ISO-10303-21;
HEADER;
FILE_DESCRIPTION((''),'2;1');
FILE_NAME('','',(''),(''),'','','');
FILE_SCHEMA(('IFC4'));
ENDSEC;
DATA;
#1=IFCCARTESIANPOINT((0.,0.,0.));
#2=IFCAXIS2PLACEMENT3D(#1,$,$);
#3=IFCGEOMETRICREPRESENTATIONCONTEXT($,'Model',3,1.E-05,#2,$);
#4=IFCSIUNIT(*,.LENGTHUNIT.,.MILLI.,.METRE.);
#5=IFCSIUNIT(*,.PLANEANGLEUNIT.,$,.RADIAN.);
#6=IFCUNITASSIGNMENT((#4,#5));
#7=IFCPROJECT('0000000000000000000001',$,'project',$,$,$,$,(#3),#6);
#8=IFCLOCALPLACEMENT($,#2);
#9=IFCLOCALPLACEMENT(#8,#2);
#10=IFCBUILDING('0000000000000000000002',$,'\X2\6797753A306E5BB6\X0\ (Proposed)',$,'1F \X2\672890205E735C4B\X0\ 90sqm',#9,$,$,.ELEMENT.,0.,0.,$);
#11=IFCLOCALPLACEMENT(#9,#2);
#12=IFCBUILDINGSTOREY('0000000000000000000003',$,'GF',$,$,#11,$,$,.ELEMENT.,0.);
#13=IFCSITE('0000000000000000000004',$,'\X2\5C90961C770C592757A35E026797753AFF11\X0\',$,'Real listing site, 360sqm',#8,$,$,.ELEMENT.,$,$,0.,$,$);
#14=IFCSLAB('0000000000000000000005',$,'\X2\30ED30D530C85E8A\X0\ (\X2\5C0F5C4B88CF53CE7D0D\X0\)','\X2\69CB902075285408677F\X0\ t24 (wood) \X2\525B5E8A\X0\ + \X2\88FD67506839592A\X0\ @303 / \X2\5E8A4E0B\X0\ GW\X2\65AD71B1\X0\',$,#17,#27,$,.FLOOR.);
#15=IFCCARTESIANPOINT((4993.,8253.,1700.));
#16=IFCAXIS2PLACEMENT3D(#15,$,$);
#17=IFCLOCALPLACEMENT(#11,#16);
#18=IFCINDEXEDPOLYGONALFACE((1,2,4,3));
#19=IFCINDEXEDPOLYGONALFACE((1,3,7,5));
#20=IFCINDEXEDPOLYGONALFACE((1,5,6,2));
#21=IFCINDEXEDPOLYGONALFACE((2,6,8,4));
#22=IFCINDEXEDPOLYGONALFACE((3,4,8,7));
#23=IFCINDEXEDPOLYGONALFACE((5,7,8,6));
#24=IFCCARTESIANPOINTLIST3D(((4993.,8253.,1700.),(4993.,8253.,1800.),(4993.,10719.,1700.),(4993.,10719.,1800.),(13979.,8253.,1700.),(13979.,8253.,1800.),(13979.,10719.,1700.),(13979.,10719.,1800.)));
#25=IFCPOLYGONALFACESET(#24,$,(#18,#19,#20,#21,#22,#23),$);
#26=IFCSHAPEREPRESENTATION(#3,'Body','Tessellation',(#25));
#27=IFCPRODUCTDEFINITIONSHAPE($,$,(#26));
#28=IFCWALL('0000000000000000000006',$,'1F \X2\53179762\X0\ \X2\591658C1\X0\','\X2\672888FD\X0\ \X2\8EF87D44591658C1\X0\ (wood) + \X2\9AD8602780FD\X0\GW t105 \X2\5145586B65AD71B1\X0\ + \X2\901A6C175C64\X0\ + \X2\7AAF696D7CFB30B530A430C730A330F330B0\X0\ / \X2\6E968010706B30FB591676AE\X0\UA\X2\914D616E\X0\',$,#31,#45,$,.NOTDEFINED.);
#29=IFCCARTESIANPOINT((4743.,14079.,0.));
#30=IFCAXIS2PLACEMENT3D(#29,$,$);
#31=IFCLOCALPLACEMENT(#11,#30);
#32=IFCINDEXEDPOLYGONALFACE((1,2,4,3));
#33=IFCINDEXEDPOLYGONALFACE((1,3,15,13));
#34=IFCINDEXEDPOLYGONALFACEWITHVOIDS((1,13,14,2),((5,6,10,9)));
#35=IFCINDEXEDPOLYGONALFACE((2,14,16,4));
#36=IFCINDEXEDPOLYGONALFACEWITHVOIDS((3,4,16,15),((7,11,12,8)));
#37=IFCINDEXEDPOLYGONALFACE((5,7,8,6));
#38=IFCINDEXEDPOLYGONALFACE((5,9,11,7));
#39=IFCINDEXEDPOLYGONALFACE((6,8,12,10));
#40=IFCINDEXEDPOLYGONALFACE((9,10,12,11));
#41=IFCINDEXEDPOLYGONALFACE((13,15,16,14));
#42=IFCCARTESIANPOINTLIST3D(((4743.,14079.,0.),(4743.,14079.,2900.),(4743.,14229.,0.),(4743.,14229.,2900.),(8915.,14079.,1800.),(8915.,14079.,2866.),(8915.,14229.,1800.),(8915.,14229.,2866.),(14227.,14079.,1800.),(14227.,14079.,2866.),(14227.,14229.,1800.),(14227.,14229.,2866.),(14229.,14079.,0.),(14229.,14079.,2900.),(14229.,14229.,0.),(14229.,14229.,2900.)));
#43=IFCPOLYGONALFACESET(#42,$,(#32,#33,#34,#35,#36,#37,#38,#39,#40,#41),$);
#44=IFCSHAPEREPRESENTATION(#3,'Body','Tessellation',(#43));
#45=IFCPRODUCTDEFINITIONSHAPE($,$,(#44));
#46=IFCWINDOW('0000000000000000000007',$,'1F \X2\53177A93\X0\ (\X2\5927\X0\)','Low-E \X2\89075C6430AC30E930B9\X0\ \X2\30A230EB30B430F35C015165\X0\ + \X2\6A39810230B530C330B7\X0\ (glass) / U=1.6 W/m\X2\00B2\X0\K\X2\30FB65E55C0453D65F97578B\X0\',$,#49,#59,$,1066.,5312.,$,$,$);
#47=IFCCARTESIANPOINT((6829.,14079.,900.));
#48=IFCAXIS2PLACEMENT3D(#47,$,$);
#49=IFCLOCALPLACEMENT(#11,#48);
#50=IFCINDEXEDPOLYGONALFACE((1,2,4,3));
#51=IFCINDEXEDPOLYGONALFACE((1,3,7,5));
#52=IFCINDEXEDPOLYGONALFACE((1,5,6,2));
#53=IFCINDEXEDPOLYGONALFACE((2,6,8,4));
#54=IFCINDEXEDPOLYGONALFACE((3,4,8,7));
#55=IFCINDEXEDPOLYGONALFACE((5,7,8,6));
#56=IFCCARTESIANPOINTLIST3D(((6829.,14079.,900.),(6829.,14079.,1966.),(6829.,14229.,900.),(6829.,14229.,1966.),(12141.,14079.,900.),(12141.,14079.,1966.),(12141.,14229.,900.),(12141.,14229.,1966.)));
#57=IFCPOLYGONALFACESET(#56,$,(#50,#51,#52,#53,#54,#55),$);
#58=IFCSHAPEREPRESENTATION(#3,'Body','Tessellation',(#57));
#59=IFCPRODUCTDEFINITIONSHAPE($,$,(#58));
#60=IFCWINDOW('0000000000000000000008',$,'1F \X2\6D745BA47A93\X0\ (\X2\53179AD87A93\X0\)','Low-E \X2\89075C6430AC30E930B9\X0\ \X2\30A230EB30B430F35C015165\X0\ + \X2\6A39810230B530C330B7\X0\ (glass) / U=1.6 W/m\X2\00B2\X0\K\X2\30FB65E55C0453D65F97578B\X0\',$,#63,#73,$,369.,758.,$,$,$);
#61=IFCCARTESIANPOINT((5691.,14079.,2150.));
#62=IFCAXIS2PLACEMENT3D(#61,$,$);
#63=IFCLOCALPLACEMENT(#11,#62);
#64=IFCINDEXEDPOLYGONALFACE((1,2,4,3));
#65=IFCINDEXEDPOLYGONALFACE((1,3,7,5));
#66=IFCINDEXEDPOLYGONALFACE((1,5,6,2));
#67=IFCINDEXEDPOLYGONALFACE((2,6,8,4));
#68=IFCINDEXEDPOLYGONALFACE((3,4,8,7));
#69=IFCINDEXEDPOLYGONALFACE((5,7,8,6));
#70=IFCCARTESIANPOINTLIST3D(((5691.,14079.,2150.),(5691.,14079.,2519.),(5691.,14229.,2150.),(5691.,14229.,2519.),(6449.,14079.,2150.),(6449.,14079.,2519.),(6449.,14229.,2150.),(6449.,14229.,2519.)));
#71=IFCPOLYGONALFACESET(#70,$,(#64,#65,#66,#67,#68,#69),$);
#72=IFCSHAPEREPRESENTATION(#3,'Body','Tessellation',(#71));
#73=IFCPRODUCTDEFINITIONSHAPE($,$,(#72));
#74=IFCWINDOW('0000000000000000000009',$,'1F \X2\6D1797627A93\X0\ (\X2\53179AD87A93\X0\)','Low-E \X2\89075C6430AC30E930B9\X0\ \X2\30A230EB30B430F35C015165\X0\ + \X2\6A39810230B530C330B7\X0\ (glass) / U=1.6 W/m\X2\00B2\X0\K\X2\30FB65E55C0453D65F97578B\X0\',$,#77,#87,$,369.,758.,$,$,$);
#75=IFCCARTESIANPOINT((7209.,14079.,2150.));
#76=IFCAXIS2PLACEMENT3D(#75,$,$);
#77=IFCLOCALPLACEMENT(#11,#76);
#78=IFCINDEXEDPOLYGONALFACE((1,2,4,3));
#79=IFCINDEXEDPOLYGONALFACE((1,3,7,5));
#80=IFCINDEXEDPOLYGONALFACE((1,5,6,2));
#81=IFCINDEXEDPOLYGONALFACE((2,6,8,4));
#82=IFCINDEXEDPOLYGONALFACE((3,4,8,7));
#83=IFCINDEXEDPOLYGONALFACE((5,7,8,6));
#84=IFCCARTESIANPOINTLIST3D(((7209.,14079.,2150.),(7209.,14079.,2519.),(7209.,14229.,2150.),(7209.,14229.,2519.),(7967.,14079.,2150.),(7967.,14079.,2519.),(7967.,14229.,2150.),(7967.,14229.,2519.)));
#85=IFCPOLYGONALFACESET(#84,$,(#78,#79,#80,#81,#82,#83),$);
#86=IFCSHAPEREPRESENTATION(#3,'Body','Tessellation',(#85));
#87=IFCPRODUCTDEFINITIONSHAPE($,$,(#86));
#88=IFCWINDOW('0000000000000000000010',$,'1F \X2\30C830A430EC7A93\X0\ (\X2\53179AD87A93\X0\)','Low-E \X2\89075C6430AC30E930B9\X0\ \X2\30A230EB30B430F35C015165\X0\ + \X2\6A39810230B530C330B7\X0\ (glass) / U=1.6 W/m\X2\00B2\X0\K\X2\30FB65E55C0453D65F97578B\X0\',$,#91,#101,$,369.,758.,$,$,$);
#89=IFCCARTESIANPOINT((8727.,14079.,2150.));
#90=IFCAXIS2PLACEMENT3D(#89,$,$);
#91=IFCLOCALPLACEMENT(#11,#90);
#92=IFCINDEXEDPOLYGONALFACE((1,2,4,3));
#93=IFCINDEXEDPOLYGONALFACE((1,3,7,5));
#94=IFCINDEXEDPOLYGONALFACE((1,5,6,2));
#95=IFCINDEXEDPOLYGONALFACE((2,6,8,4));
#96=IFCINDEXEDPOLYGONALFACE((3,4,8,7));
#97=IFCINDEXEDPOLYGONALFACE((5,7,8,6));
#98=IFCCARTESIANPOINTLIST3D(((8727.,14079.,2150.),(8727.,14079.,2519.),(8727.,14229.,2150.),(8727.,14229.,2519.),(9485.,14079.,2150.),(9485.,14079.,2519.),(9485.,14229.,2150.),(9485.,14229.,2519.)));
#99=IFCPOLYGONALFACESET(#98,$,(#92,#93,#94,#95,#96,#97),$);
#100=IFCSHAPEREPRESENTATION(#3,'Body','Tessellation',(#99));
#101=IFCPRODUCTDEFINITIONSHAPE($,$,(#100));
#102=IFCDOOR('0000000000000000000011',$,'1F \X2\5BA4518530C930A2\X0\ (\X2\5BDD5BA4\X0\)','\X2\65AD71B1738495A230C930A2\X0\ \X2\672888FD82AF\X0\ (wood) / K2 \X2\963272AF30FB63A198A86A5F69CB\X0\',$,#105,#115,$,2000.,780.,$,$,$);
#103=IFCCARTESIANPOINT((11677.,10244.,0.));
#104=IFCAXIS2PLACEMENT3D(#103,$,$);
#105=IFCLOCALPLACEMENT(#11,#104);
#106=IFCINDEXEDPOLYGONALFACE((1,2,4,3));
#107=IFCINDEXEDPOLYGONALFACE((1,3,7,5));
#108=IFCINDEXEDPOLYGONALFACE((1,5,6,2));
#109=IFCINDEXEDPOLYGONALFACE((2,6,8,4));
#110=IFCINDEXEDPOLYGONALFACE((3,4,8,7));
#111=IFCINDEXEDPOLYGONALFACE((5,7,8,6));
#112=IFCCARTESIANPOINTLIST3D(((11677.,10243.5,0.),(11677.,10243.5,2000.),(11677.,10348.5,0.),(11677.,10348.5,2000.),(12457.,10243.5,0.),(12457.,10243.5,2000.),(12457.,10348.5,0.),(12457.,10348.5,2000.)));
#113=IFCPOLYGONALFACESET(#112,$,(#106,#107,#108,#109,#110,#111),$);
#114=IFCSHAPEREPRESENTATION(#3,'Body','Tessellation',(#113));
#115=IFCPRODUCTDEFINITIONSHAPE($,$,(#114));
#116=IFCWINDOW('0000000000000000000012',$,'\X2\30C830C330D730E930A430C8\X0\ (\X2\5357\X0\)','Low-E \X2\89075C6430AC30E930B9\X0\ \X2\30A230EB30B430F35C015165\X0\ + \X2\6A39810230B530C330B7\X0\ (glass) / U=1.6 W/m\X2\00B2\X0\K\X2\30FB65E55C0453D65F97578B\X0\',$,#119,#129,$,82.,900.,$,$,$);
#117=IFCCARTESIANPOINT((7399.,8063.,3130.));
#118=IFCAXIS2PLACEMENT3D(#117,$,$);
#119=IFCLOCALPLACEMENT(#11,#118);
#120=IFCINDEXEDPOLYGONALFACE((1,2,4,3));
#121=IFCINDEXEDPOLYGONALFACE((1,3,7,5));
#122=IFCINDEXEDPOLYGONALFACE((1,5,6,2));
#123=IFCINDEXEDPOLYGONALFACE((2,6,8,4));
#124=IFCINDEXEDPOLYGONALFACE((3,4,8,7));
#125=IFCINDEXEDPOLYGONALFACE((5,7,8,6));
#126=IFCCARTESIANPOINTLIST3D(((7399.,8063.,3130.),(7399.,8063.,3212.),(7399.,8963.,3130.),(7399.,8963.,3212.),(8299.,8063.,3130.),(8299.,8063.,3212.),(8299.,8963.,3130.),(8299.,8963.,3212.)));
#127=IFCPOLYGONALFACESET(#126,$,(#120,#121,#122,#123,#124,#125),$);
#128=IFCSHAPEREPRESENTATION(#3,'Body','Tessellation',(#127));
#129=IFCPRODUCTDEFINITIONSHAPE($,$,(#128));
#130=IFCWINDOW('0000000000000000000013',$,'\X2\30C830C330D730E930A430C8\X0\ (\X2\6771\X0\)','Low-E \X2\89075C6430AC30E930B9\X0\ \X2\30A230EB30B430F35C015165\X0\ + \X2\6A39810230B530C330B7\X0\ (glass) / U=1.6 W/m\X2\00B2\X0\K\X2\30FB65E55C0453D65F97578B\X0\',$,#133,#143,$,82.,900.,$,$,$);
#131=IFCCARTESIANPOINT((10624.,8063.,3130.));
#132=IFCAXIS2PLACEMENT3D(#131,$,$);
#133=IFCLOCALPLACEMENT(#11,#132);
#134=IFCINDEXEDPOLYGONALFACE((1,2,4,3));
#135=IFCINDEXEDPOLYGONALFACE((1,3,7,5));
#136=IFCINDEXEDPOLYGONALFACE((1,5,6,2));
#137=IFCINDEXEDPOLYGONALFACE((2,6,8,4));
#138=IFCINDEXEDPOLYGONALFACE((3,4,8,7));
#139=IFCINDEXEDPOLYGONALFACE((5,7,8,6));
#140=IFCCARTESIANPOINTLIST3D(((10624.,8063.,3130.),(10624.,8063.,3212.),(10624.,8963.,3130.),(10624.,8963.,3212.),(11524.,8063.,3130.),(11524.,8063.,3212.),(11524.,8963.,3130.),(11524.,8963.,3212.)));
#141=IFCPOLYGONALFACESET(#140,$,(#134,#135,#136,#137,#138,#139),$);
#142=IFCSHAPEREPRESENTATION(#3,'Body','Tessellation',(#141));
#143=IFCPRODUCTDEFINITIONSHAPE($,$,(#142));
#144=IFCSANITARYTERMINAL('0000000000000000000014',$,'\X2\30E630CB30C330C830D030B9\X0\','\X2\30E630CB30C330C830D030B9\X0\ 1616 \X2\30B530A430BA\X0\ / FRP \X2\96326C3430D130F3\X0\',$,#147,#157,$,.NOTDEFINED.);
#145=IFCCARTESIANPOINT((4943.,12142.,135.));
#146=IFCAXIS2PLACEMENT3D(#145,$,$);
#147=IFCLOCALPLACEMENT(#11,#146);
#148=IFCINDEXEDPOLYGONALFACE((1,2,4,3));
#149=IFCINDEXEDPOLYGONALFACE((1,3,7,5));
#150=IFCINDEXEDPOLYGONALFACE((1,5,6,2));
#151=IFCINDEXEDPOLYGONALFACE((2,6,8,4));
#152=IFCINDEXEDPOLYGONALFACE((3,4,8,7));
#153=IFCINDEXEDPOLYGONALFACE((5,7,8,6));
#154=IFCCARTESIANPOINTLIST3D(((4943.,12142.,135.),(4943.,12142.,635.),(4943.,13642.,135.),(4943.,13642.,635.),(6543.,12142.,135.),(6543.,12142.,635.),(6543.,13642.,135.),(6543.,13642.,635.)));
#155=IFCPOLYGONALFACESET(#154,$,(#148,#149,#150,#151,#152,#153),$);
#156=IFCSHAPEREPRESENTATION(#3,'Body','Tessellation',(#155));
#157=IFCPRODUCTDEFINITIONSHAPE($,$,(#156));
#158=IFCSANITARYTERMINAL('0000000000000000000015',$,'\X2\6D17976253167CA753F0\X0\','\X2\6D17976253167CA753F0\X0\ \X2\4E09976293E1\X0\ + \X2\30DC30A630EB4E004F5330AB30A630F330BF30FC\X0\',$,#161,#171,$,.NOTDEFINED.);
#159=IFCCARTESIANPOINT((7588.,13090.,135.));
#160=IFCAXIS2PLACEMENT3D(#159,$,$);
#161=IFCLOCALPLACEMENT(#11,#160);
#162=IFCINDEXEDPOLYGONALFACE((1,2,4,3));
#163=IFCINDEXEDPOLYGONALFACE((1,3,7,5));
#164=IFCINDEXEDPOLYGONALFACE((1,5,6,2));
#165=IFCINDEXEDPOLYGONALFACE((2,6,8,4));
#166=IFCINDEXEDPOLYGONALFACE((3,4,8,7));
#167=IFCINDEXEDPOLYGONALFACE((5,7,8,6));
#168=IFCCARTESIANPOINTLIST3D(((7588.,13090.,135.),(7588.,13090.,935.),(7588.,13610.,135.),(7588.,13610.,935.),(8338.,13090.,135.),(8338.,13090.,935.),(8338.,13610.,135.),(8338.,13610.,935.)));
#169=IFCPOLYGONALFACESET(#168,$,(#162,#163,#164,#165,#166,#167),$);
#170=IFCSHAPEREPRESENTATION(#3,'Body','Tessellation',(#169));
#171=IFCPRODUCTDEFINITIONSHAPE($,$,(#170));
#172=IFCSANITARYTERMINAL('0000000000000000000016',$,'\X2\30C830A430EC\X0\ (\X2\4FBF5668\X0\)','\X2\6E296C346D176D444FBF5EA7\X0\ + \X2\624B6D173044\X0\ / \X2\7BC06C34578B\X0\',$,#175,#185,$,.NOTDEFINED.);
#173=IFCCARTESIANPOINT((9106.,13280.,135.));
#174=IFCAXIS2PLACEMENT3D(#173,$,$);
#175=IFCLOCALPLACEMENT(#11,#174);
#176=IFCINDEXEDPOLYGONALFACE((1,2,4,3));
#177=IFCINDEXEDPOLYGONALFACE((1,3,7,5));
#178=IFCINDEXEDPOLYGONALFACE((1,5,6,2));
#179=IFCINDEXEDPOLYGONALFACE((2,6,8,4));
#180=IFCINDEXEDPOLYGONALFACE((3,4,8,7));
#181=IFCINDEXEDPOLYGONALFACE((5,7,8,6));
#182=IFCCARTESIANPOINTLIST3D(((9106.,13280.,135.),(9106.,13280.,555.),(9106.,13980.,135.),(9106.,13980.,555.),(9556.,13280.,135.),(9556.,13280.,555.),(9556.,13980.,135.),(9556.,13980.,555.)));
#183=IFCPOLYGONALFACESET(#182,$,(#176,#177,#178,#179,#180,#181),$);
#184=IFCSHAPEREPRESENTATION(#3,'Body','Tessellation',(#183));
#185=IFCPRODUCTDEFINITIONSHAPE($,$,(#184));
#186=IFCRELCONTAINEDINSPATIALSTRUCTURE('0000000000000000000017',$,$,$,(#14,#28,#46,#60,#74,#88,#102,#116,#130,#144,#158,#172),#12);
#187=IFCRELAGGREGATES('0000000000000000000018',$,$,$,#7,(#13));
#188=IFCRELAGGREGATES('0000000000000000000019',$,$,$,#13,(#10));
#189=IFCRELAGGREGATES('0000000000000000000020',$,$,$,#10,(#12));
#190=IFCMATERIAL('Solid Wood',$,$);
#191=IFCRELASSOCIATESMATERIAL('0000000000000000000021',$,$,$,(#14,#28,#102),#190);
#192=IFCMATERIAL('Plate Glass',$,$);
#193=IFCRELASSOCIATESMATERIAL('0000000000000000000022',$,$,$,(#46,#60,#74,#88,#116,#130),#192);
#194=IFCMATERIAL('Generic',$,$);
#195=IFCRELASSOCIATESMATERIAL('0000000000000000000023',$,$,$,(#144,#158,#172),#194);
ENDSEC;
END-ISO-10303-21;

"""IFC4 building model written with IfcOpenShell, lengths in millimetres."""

from ifc_helpers import new_model, si_unit, frame, frame_2d, origin, place, context, project, spatial, rectangle, extrude, material, element, fill, save


model = new_model("IFC4")

# Units and contexts
model_context = context("Model", 3, precision=1e-05, world=origin())
ifc_project = project(units=[si_unit("LENGTHUNIT", "METRE", prefix="MILLI"), si_unit("PLANEANGLEUNIT", "RADIAN")], contexts=[model_context])

# Site, building, storey
site_placement = place(None, origin())
site = spatial("IfcSite", under=ifc_project, at=site_placement, Name="岐阜県大垣市林町１", ObjectType="Real listing site, 360sqm", CompositionType="ELEMENT", RefElevation=0.0)
building_placement = place(site_placement, origin())
building = spatial("IfcBuilding", under=site, at=building_placement, Name="林町の家 (Proposed)", ObjectType="1F 木造平屋 90sqm", CompositionType="ELEMENT", ElevationOfRefHeight=0.0, ElevationOfTerrain=0.0)
storey_placement = place(building_placement, origin())
storey = spatial("IfcBuildingStorey", under=building, at=storey_placement, Name="GF", CompositionType="ELEMENT", Elevation=0.0)

# Slab
ifc_material_1 = material(Name="Solid Wood")
slab_placement = place(storey_placement, frame((4993.0, 8253.0, 1700.0)))
element("IfcSlab", 1, at=slab_placement, inside=storey, material=ifc_material_1, Name="ロフト床 (小屋裏収納)", Description="構造用合板 t24 (wood) 剛床 + 製材根太 @303 / 床下 GW断熱", PredefinedType="FLOOR", context=model_context, shape_type="SweptSolid", body=[
    extrude(rectangle(XDim=8986.0, YDim=2466.0, at=frame_2d((4493.0, 1233.0))), frame((4993.0, 8253.0, 1700.0)), (0.0, 0.0, 1.0), 100.0),
])

# Wall, openings, windows
wall_1_placement = place(storey_placement, frame((4743.0, 14079.0, 0.0)))
wall_1 = element("IfcWall", 2, at=wall_1_placement, inside=storey, material=ifc_material_1, Name="1F 北面 外壁", Description="木製 軸組外壁 (wood) + 高性能GW t105 充填断熱 + 通気層 + 窯業系サイディング / 準耐火・外皮UA配慮", PredefinedType="NOTDEFINED", context=model_context, shape_type="SweptSolid", body=[
    extrude(rectangle(XDim=9486.0, YDim=150.0, at=frame_2d((4743.0, 75.0))), frame((4743.0, 14079.0, 0.0)), (0.0, 0.0, 1.0), 2900.0),
])
opening_1_placement = place(storey_placement, frame((6829.0, 14079.0, 900.0)))
opening_1 = element("IfcOpeningElement", 3, at=opening_1_placement, cuts=wall_1, PredefinedType="NOTDEFINED", context=model_context, shape_type="SweptSolid", body=[
    extrude(rectangle(XDim=5312.0, YDim=150.0, at=frame_2d((2656.0, 75.0))), frame((6829.0, 14079.0, 900.0)), (0.0, 0.0, 1.0), 1066.0),
])
opening_2_placement = place(storey_placement, frame((5691.0, 14079.0, 2150.0)))
opening_2 = element("IfcOpeningElement", 4, at=opening_2_placement, cuts=wall_1, PredefinedType="NOTDEFINED", context=model_context, shape_type="SweptSolid", body=[
    extrude(rectangle(XDim=758.0, YDim=150.0, at=frame_2d((379.0, 75.0))), frame((5691.0, 14079.0, 2150.0)), (0.0, 0.0, 1.0), 369.0),
])
opening_3_placement = place(storey_placement, frame((7209.0, 14079.0, 2150.0)))
opening_3 = element("IfcOpeningElement", 5, at=opening_3_placement, cuts=wall_1, PredefinedType="NOTDEFINED", context=model_context, shape_type="SweptSolid", body=[
    extrude(rectangle(XDim=758.0, YDim=150.0, at=frame_2d((379.0, 75.0))), frame((7209.0, 14079.0, 2150.0)), (0.0, 0.0, 1.0), 369.0),
])
opening_4_placement = place(storey_placement, frame((8727.0, 14079.0, 2150.0)))
opening_4 = element("IfcOpeningElement", 6, at=opening_4_placement, cuts=wall_1, PredefinedType="NOTDEFINED", context=model_context, shape_type="SweptSolid", body=[
    extrude(rectangle(XDim=758.0, YDim=150.0, at=frame_2d((379.0, 75.0))), frame((8727.0, 14079.0, 2150.0)), (0.0, 0.0, 1.0), 369.0),
])
ifc_material_2 = material(Name="Plate Glass")
window_1_placement = place(storey_placement, frame((6829.0, 14079.0, 900.0)))
window_1 = element("IfcWindow", 7, at=window_1_placement, inside=storey, material=ifc_material_2, Name="1F 北窓 (大)", Description="Low-E 複層ガラス アルゴン封入 + 樹脂サッシ (glass) / U=1.6 W/m²K・日射取得型", OverallHeight=1066.0, OverallWidth=5312.0, context=model_context, shape_type="SweptSolid", body=[
    extrude(rectangle(XDim=5312.0, YDim=150.0, at=frame_2d((2656.0, 75.0))), frame((6829.0, 14079.0, 900.0)), (0.0, 0.0, 1.0), 1066.0),
])
fill(opening_1, window_1)
window_2_placement = place(storey_placement, frame((5691.0, 14079.0, 2150.0)))
window_2 = element("IfcWindow", 8, at=window_2_placement, inside=storey, material=ifc_material_2, Name="1F 浴室窓 (北高窓)", Description="Low-E 複層ガラス アルゴン封入 + 樹脂サッシ (glass) / U=1.6 W/m²K・日射取得型", OverallHeight=369.0, OverallWidth=758.0, context=model_context, shape_type="SweptSolid", body=[
    extrude(rectangle(XDim=758.0, YDim=150.0, at=frame_2d((379.0, 75.0))), frame((5691.0, 14079.0, 2150.0)), (0.0, 0.0, 1.0), 369.0),
])
fill(opening_2, window_2)
window_3_placement = place(storey_placement, frame((7209.0, 14079.0, 2150.0)))
window_3 = element("IfcWindow", 9, at=window_3_placement, inside=storey, material=ifc_material_2, Name="1F 洗面窓 (北高窓)", Description="Low-E 複層ガラス アルゴン封入 + 樹脂サッシ (glass) / U=1.6 W/m²K・日射取得型", OverallHeight=369.0, OverallWidth=758.0, context=model_context, shape_type="SweptSolid", body=[
    extrude(rectangle(XDim=758.0, YDim=150.0, at=frame_2d((379.0, 75.0))), frame((7209.0, 14079.0, 2150.0)), (0.0, 0.0, 1.0), 369.0),
])
fill(opening_3, window_3)
window_4_placement = place(storey_placement, frame((8727.0, 14079.0, 2150.0)))
window_4 = element("IfcWindow", 10, at=window_4_placement, inside=storey, material=ifc_material_2, Name="1F トイレ窓 (北高窓)", Description="Low-E 複層ガラス アルゴン封入 + 樹脂サッシ (glass) / U=1.6 W/m²K・日射取得型", OverallHeight=369.0, OverallWidth=758.0, context=model_context, shape_type="SweptSolid", body=[
    extrude(rectangle(XDim=758.0, YDim=150.0, at=frame_2d((379.0, 75.0))), frame((8727.0, 14079.0, 2150.0)), (0.0, 0.0, 1.0), 369.0),
])
fill(opening_4, window_4)

# Door
door_1_placement = place(storey_placement, frame((11677.0, 10244.0, 0.0)))
element("IfcDoor", 11, at=door_1_placement, inside=storey, material=ifc_material_1, Name="1F 室内ドア (寝室)", Description="断熱玄関ドア 木製芯 (wood) / K2 防犯・採風機構", OverallHeight=2000.0, OverallWidth=780.0, context=model_context, shape_type="SweptSolid", body=[
    extrude(rectangle(XDim=780.0, YDim=105.0, at=frame_2d((390.0, 52.0))), frame((11677.0, 10244.0, 0.0)), (0.0, 0.0, 1.0), 2000.0),
])

# Windows
window_5_placement = place(storey_placement, frame((7399.0, 8063.0, 3130.0)))
element("IfcWindow", 12, at=window_5_placement, inside=storey, material=ifc_material_2, Name="トップライト (南)", Description="Low-E 複層ガラス アルゴン封入 + 樹脂サッシ (glass) / U=1.6 W/m²K・日射取得型", OverallHeight=82.0, OverallWidth=900.0, context=model_context, shape_type="SweptSolid", body=[
    extrude(rectangle(XDim=900.0, YDim=900.0, at=frame_2d((450.0, 450.0))), frame((7399.0, 8063.0, 3130.0)), (0.0, 0.0, 1.0), 82.0),
])
window_6_placement = place(storey_placement, frame((10624.0, 8063.0, 3130.0)))
element("IfcWindow", 13, at=window_6_placement, inside=storey, material=ifc_material_2, Name="トップライト (東)", Description="Low-E 複層ガラス アルゴン封入 + 樹脂サッシ (glass) / U=1.6 W/m²K・日射取得型", OverallHeight=82.0, OverallWidth=900.0, context=model_context, shape_type="SweptSolid", body=[
    extrude(rectangle(XDim=900.0, YDim=900.0, at=frame_2d((450.0, 450.0))), frame((10624.0, 8063.0, 3130.0)), (0.0, 0.0, 1.0), 82.0),
])

# Sanitary terminals
ifc_material_3 = material(Name="Generic")
sanitary_terminal_1_placement = place(storey_placement, frame((4943.0, 12142.0, 135.0)))
element("IfcSanitaryTerminal", 14, at=sanitary_terminal_1_placement, inside=storey, material=ifc_material_3, Name="ユニットバス", Description="ユニットバス 1616 サイズ / FRP 防水パン", PredefinedType="NOTDEFINED", context=model_context, shape_type="SweptSolid", body=[
    extrude(rectangle(XDim=1600.0, YDim=1500.0, at=frame_2d((800.0, 750.0))), frame((4943.0, 12142.0, 135.0)), (0.0, 0.0, 1.0), 500.0),
])
sanitary_terminal_2_placement = place(storey_placement, frame((7588.0, 13090.0, 135.0)))
element("IfcSanitaryTerminal", 15, at=sanitary_terminal_2_placement, inside=storey, material=ifc_material_3, Name="洗面化粧台", Description="洗面化粧台 三面鏡 + ボウル一体カウンター", PredefinedType="NOTDEFINED", context=model_context, shape_type="SweptSolid", body=[
    extrude(rectangle(XDim=750.0, YDim=520.0, at=frame_2d((375.0, 260.0))), frame((7588.0, 13090.0, 135.0)), (0.0, 0.0, 1.0), 800.0),
])
sanitary_terminal_3_placement = place(storey_placement, frame((9106.0, 13280.0, 135.0)))
element("IfcSanitaryTerminal", 16, at=sanitary_terminal_3_placement, inside=storey, material=ifc_material_3, Name="トイレ (便器)", Description="温水洗浄便座 + 手洗い / 節水型", PredefinedType="NOTDEFINED", context=model_context, shape_type="SweptSolid", body=[
    extrude(rectangle(XDim=450.0, YDim=700.0, at=frame_2d((225.0, 350.0))), frame((9106.0, 13280.0, 135.0)), (0.0, 0.0, 1.0), 420.0),
])

save(model, "model.ifc")
